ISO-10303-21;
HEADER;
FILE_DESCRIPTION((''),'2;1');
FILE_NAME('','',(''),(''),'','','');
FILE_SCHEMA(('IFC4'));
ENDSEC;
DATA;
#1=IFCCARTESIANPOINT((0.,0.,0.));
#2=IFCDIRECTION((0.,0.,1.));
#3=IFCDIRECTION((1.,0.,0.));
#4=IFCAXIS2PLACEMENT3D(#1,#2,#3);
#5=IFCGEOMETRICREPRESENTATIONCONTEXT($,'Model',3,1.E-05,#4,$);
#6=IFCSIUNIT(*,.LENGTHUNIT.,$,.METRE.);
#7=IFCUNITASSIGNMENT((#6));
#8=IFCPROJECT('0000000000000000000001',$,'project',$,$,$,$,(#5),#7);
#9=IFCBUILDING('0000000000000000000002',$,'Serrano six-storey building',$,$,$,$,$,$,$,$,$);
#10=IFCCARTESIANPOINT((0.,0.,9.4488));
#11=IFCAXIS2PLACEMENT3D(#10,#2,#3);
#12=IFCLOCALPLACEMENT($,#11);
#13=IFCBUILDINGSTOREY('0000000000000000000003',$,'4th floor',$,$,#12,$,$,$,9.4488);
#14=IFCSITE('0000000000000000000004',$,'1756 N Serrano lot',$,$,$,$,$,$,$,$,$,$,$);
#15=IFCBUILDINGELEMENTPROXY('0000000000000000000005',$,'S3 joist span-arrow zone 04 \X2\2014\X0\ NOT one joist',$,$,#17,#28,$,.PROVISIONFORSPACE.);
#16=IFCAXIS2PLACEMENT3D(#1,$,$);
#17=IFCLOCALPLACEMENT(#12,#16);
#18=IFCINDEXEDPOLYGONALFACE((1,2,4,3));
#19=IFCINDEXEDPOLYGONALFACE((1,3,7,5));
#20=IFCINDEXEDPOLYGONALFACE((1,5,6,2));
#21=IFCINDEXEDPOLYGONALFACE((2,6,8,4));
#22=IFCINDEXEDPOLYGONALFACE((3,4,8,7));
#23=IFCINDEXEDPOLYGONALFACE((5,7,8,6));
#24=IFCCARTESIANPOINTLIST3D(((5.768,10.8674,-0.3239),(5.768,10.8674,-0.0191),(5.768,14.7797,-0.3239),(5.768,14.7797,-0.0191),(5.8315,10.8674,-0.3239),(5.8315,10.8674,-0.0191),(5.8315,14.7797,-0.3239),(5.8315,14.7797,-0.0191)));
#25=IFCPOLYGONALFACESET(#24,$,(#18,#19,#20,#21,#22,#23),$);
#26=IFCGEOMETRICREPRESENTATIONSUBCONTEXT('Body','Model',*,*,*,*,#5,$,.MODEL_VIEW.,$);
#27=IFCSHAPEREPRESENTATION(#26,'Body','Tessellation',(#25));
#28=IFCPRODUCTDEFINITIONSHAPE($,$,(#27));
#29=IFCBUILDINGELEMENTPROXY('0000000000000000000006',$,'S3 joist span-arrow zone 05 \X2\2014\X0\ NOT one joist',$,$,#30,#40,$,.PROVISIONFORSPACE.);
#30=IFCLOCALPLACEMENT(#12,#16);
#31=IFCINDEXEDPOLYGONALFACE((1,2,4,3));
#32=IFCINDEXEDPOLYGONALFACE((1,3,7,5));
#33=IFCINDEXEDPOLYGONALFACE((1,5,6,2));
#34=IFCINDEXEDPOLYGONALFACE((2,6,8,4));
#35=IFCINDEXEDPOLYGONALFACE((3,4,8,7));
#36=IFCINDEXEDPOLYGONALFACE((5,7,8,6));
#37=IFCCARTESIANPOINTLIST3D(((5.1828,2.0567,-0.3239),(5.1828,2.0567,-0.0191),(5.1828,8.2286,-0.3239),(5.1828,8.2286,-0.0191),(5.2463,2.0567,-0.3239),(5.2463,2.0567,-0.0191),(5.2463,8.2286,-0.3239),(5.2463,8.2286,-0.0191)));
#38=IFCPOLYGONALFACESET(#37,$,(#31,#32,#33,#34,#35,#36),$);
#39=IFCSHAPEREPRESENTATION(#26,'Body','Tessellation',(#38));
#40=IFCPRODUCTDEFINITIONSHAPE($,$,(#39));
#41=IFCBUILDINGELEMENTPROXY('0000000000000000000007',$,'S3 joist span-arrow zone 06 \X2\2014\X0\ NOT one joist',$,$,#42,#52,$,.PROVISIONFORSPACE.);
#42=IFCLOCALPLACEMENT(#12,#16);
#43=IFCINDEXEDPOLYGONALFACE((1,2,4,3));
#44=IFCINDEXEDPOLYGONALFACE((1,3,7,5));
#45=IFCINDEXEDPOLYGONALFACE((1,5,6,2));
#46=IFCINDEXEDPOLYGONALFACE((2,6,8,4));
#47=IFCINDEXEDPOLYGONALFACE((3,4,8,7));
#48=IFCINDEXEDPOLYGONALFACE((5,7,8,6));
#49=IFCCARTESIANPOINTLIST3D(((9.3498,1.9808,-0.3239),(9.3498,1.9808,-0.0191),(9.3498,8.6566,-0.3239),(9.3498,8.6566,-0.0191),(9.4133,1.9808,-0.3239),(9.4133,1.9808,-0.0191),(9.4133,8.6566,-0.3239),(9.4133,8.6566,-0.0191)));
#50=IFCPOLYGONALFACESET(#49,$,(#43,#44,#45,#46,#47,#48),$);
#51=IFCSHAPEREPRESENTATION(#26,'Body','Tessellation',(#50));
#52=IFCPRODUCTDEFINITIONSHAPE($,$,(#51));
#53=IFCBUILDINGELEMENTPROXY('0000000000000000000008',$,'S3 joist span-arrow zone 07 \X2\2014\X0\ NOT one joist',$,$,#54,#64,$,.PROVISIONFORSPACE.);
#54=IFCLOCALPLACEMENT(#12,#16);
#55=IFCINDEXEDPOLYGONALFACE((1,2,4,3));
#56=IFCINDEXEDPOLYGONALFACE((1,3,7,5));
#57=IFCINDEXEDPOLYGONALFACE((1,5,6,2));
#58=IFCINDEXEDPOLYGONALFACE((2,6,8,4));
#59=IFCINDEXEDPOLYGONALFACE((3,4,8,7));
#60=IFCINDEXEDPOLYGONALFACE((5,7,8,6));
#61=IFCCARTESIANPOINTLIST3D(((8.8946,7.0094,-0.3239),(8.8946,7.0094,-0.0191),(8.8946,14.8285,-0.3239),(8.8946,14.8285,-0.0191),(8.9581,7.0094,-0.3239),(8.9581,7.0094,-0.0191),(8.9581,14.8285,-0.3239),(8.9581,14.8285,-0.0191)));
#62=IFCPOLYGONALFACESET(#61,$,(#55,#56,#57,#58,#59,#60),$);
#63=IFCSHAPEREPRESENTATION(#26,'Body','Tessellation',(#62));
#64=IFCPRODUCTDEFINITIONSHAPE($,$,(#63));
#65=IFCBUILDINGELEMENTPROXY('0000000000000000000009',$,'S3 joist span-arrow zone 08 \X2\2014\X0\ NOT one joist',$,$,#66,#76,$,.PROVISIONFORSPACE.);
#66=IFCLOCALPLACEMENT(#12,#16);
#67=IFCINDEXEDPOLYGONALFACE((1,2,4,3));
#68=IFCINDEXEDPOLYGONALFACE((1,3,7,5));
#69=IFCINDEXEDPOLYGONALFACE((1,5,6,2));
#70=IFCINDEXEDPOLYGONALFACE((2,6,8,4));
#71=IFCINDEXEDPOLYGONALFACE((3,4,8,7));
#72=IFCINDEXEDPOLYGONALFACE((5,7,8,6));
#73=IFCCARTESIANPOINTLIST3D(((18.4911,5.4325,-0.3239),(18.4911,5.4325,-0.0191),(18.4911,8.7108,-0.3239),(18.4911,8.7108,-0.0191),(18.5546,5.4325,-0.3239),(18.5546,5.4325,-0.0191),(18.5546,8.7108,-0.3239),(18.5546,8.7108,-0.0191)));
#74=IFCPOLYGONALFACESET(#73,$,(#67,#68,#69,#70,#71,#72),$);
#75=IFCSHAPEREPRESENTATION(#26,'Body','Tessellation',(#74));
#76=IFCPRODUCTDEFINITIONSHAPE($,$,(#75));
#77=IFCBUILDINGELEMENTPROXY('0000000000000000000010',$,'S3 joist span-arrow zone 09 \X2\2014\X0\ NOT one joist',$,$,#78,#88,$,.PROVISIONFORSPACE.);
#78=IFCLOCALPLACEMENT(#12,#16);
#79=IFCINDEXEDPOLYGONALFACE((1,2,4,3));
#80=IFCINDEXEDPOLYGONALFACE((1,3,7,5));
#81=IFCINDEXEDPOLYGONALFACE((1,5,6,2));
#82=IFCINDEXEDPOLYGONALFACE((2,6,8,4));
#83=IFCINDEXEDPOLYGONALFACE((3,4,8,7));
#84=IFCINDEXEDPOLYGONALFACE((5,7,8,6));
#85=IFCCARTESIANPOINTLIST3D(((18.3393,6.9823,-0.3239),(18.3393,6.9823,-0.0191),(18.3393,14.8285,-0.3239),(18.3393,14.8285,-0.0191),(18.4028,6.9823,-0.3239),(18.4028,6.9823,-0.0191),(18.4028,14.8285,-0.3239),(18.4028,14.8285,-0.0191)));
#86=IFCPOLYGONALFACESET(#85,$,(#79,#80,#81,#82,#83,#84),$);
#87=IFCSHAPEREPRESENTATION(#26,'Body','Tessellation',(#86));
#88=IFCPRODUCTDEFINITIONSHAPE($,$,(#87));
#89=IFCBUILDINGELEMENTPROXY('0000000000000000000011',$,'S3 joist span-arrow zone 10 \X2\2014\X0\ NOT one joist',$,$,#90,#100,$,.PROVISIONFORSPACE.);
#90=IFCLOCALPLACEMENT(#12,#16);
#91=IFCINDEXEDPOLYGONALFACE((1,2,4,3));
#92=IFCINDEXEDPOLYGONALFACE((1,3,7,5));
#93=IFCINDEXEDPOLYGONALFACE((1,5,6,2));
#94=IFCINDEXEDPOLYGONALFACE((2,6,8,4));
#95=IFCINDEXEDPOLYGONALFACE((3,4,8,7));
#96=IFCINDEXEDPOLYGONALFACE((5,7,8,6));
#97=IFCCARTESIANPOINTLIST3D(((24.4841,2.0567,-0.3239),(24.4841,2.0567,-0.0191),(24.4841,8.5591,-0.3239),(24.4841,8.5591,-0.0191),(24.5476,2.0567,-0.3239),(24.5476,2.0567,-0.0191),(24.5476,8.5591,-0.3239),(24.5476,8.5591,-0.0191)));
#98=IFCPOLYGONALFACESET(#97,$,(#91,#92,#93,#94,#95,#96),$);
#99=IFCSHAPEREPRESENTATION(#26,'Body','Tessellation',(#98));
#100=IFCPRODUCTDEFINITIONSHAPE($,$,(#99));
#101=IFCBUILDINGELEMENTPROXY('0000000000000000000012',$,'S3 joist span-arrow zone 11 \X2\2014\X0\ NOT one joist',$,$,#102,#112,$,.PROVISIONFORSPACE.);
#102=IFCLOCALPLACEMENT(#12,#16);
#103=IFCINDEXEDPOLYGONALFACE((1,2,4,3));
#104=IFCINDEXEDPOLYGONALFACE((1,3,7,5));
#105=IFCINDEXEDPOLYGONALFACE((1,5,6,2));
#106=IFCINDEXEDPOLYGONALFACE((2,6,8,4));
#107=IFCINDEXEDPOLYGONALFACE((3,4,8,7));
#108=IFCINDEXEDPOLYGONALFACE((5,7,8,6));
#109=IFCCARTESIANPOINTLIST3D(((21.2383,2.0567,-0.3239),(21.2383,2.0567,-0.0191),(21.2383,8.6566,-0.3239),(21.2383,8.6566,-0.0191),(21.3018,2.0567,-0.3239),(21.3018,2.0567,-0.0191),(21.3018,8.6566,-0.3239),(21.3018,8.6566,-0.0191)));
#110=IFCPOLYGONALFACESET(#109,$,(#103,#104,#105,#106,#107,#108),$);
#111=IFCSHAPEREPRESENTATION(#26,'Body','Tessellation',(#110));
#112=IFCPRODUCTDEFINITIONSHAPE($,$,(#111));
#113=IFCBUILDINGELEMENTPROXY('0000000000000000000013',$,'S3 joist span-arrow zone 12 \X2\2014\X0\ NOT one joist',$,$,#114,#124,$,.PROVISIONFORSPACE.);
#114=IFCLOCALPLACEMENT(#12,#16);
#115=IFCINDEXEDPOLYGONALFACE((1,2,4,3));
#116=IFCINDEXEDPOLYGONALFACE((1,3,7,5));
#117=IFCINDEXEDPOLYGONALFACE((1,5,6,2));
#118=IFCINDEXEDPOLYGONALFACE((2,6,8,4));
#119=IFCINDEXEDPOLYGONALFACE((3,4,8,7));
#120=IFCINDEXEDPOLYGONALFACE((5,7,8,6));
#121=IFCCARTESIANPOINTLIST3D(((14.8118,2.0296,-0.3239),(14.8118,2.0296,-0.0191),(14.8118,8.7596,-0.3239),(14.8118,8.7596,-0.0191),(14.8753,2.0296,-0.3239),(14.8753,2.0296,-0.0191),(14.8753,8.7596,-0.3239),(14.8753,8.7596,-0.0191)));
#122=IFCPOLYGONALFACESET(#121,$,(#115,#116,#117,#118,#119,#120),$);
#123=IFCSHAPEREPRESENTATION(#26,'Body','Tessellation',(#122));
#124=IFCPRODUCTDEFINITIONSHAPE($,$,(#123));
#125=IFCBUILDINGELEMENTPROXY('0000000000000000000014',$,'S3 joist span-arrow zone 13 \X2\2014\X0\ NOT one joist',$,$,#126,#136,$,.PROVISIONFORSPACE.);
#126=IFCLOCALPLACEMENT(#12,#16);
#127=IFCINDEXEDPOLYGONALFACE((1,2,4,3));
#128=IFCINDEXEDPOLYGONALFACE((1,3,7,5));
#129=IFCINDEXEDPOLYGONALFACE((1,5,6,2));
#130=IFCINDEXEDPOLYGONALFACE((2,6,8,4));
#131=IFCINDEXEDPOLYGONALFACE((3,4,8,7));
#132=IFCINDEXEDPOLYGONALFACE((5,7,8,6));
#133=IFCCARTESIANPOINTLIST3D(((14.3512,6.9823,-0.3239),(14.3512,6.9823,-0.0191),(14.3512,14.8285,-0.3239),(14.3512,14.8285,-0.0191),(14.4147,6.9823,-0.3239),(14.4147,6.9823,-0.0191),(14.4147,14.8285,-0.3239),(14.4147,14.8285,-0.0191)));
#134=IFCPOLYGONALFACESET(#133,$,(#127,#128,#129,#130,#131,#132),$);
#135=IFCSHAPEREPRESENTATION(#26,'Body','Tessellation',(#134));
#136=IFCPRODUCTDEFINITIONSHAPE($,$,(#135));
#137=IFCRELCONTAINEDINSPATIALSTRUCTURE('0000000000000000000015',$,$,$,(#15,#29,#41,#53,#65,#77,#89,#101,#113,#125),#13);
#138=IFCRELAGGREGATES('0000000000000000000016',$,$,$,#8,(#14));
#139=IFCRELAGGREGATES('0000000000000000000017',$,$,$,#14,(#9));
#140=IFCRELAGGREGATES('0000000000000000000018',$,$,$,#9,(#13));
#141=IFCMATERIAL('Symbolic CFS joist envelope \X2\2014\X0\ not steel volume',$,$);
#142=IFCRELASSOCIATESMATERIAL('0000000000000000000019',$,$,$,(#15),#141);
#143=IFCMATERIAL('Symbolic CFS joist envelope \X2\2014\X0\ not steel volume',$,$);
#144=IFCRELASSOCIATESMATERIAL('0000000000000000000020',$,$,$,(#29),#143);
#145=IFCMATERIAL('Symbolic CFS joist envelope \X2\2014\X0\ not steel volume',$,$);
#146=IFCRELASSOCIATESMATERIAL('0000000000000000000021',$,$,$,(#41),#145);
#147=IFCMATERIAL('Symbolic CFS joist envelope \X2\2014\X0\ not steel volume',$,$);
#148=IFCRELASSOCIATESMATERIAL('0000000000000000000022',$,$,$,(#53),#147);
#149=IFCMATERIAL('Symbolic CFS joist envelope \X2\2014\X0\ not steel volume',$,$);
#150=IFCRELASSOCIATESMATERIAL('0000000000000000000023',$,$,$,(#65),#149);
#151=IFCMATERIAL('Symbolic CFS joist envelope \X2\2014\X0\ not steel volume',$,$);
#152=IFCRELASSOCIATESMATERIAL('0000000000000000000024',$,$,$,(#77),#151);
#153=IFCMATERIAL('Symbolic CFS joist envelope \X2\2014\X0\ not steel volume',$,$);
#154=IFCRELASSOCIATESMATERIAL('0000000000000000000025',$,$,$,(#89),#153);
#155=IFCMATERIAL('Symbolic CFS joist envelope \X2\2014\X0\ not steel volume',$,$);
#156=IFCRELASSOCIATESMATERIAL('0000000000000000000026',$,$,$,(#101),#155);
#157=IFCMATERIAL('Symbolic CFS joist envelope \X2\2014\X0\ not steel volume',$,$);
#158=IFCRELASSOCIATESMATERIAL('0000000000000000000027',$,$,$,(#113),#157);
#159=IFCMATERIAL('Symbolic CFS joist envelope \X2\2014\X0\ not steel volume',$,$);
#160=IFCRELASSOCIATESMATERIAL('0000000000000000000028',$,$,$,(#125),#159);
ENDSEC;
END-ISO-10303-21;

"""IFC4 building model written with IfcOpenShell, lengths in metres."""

from ifc_helpers import new_model, si_unit, frame, origin_with_axes, place, context, subcontext, project, spatial, polyline, outline, extrude, material, element, save


model = new_model("IFC4")

# Units and contexts
model_context = context("Model", 3, precision=1e-05, world=origin_with_axes())
body_context = subcontext(model_context, "Body", "Model", "MODEL_VIEW")
ifc_project = project(units=[si_unit("LENGTHUNIT", "METRE")], contexts=[model_context])

# Site, building, storey
site = spatial("IfcSite", under=ifc_project, Name="1756 N Serrano lot")
building = spatial("IfcBuilding", under=site, Name="Serrano six-storey building")
storey_placement = place(None, frame((0.0, 0.0, 9.4488), z_axis=(0.0, 0.0, 1.0), x_axis=(1.0, 0.0, 0.0)))
storey = spatial("IfcBuildingStorey", under=building, at=storey_placement, Name="4th floor", Elevation=9.4488)

# Building element proxies
ifc_material_1 = material(Name="Symbolic CFS joist envelope — not steel volume")
proxy_1_placement = place(storey_placement, frame((0.0, 0.0, -9.4488), z_axis=(0.0, 0.0, 1.0), x_axis=(1.0, 0.0, 0.0)))
element("IfcBuildingElementProxy", 1, at=proxy_1_placement, inside=storey, material=ifc_material_1, Name="S3 joist span-arrow zone 04 — NOT one joist", PredefinedType="PROVISIONFORSPACE", context=body_context, shape_type="SweptSolid", body=[
    extrude(outline(polyline([(5.768, 14.7797), (5.8315, 14.7797), (5.8315, 10.8674), (5.768, 10.8674), (5.768, 14.7797)])), frame((0.0, 0.0, 9.125)), (0.0, 0.0, 1.0), 0.3048),
])
ifc_material_2 = material(Name="Symbolic CFS joist envelope — not steel volume")
proxy_2_placement = place(storey_placement, frame((0.0, 0.0, -9.4488), z_axis=(0.0, 0.0, 1.0), x_axis=(1.0, 0.0, 0.0)))
element("IfcBuildingElementProxy", 2, at=proxy_2_placement, inside=storey, material=ifc_material_2, Name="S3 joist span-arrow zone 05 — NOT one joist", PredefinedType="PROVISIONFORSPACE", context=body_context, shape_type="SweptSolid", body=[
    extrude(outline(polyline([(5.1828, 8.2286), (5.2463, 8.2286), (5.2463, 2.0567), (5.1828, 2.0567), (5.1828, 8.2286)])), frame((0.0, 0.0, 9.125)), (0.0, 0.0, 1.0), 0.3048),
])
ifc_material_3 = material(Name="Symbolic CFS joist envelope — not steel volume")
proxy_3_placement = place(storey_placement, frame((0.0, 0.0, -9.4488), z_axis=(0.0, 0.0, 1.0), x_axis=(1.0, 0.0, 0.0)))
element("IfcBuildingElementProxy", 3, at=proxy_3_placement, inside=storey, material=ifc_material_3, Name="S3 joist span-arrow zone 06 — NOT one joist", PredefinedType="PROVISIONFORSPACE", context=body_context, shape_type="SweptSolid", body=[
    extrude(outline(polyline([(9.3498, 8.6566), (9.4133, 8.6566), (9.4133, 1.9808), (9.3498, 1.9808), (9.3498, 8.6566)])), frame((0.0, 0.0, 9.125)), (0.0, 0.0, 1.0), 0.3048),
])
ifc_material_4 = material(Name="Symbolic CFS joist envelope — not steel volume")
proxy_4_placement = place(storey_placement, frame((0.0, 0.0, -9.4488), z_axis=(0.0, 0.0, 1.0), x_axis=(1.0, 0.0, 0.0)))
element("IfcBuildingElementProxy", 4, at=proxy_4_placement, inside=storey, material=ifc_material_4, Name="S3 joist span-arrow zone 07 — NOT one joist", PredefinedType="PROVISIONFORSPACE", context=body_context, shape_type="SweptSolid", body=[
    extrude(outline(polyline([(8.8946, 14.8285), (8.9581, 14.8285), (8.9581, 7.0094), (8.8946, 7.0094), (8.8946, 14.8285)])), frame((0.0, 0.0, 9.125)), (0.0, 0.0, 1.0), 0.3048),
])
ifc_material_5 = material(Name="Symbolic CFS joist envelope — not steel volume")
proxy_5_placement = place(storey_placement, frame((0.0, 0.0, -9.4488), z_axis=(0.0, 0.0, 1.0), x_axis=(1.0, 0.0, 0.0)))
element("IfcBuildingElementProxy", 5, at=proxy_5_placement, inside=storey, material=ifc_material_5, Name="S3 joist span-arrow zone 08 — NOT one joist", PredefinedType="PROVISIONFORSPACE", context=body_context, shape_type="SweptSolid", body=[
    extrude(outline(polyline([(18.4911, 8.7108), (18.5546, 8.7108), (18.5546, 5.4325), (18.4911, 5.4325), (18.4911, 8.7108)])), frame((0.0, 0.0, 9.125)), (0.0, 0.0, 1.0), 0.3048),
])
ifc_material_6 = material(Name="Symbolic CFS joist envelope — not steel volume")
proxy_6_placement = place(storey_placement, frame((0.0, 0.0, -9.4488), z_axis=(0.0, 0.0, 1.0), x_axis=(1.0, 0.0, 0.0)))
element("IfcBuildingElementProxy", 6, at=proxy_6_placement, inside=storey, material=ifc_material_6, Name="S3 joist span-arrow zone 09 — NOT one joist", PredefinedType="PROVISIONFORSPACE", context=body_context, shape_type="SweptSolid", body=[
    extrude(outline(polyline([(18.3393, 14.8285), (18.4028, 14.8285), (18.4028, 6.9823), (18.3393, 6.9823), (18.3393, 14.8285)])), frame((0.0, 0.0, 9.125)), (0.0, 0.0, 1.0), 0.3048),
])
ifc_material_7 = material(Name="Symbolic CFS joist envelope — not steel volume")
proxy_7_placement = place(storey_placement, frame((0.0, 0.0, -9.4488), z_axis=(0.0, 0.0, 1.0), x_axis=(1.0, 0.0, 0.0)))
element("IfcBuildingElementProxy", 7, at=proxy_7_placement, inside=storey, material=ifc_material_7, Name="S3 joist span-arrow zone 10 — NOT one joist", PredefinedType="PROVISIONFORSPACE", context=body_context, shape_type="SweptSolid", body=[
    extrude(outline(polyline([(24.4841, 8.5591), (24.5476, 8.5591), (24.5476, 2.0567), (24.4841, 2.0567), (24.4841, 8.5591)])), frame((0.0, 0.0, 9.125)), (0.0, 0.0, 1.0), 0.3048),
])
ifc_material_8 = material(Name="Symbolic CFS joist envelope — not steel volume")
proxy_8_placement = place(storey_placement, frame((0.0, 0.0, -9.4488), z_axis=(0.0, 0.0, 1.0), x_axis=(1.0, 0.0, 0.0)))
element("IfcBuildingElementProxy", 8, at=proxy_8_placement, inside=storey, material=ifc_material_8, Name="S3 joist span-arrow zone 11 — NOT one joist", PredefinedType="PROVISIONFORSPACE", context=body_context, shape_type="SweptSolid", body=[
    extrude(outline(polyline([(21.2383, 8.6566), (21.3018, 8.6566), (21.3018, 2.0567), (21.2383, 2.0567), (21.2383, 8.6566)])), frame((0.0, 0.0, 9.125)), (0.0, 0.0, 1.0), 0.3048),
])
ifc_material_9 = material(Name="Symbolic CFS joist envelope — not steel volume")
proxy_9_placement = place(storey_placement, frame((0.0, 0.0, -9.4488), z_axis=(0.0, 0.0, 1.0), x_axis=(1.0, 0.0, 0.0)))
element("IfcBuildingElementProxy", 9, at=proxy_9_placement, inside=storey, material=ifc_material_9, Name="S3 joist span-arrow zone 12 — NOT one joist", PredefinedType="PROVISIONFORSPACE", context=body_context, shape_type="SweptSolid", body=[
    extrude(outline(polyline([(14.8118, 8.7596), (14.8753, 8.7596), (14.8753, 2.0296), (14.8118, 2.0296), (14.8118, 8.7596)])), frame((0.0, 0.0, 9.125)), (0.0, 0.0, 1.0), 0.3048),
])
ifc_material_10 = material(Name="Symbolic CFS joist envelope — not steel volume")
proxy_10_placement = place(storey_placement, frame((0.0, 0.0, -9.4488), z_axis=(0.0, 0.0, 1.0), x_axis=(1.0, 0.0, 0.0)))
element("IfcBuildingElementProxy", 10, at=proxy_10_placement, inside=storey, material=ifc_material_10, Name="S3 joist span-arrow zone 13 — NOT one joist", PredefinedType="PROVISIONFORSPACE", context=body_context, shape_type="SweptSolid", body=[
    extrude(outline(polyline([(14.3512, 14.8285), (14.4147, 14.8285), (14.4147, 6.9823), (14.3512, 6.9823), (14.3512, 14.8285)])), frame((0.0, 0.0, 9.125)), (0.0, 0.0, 1.0), 0.3048),
])

save(model, "model.ifc")
